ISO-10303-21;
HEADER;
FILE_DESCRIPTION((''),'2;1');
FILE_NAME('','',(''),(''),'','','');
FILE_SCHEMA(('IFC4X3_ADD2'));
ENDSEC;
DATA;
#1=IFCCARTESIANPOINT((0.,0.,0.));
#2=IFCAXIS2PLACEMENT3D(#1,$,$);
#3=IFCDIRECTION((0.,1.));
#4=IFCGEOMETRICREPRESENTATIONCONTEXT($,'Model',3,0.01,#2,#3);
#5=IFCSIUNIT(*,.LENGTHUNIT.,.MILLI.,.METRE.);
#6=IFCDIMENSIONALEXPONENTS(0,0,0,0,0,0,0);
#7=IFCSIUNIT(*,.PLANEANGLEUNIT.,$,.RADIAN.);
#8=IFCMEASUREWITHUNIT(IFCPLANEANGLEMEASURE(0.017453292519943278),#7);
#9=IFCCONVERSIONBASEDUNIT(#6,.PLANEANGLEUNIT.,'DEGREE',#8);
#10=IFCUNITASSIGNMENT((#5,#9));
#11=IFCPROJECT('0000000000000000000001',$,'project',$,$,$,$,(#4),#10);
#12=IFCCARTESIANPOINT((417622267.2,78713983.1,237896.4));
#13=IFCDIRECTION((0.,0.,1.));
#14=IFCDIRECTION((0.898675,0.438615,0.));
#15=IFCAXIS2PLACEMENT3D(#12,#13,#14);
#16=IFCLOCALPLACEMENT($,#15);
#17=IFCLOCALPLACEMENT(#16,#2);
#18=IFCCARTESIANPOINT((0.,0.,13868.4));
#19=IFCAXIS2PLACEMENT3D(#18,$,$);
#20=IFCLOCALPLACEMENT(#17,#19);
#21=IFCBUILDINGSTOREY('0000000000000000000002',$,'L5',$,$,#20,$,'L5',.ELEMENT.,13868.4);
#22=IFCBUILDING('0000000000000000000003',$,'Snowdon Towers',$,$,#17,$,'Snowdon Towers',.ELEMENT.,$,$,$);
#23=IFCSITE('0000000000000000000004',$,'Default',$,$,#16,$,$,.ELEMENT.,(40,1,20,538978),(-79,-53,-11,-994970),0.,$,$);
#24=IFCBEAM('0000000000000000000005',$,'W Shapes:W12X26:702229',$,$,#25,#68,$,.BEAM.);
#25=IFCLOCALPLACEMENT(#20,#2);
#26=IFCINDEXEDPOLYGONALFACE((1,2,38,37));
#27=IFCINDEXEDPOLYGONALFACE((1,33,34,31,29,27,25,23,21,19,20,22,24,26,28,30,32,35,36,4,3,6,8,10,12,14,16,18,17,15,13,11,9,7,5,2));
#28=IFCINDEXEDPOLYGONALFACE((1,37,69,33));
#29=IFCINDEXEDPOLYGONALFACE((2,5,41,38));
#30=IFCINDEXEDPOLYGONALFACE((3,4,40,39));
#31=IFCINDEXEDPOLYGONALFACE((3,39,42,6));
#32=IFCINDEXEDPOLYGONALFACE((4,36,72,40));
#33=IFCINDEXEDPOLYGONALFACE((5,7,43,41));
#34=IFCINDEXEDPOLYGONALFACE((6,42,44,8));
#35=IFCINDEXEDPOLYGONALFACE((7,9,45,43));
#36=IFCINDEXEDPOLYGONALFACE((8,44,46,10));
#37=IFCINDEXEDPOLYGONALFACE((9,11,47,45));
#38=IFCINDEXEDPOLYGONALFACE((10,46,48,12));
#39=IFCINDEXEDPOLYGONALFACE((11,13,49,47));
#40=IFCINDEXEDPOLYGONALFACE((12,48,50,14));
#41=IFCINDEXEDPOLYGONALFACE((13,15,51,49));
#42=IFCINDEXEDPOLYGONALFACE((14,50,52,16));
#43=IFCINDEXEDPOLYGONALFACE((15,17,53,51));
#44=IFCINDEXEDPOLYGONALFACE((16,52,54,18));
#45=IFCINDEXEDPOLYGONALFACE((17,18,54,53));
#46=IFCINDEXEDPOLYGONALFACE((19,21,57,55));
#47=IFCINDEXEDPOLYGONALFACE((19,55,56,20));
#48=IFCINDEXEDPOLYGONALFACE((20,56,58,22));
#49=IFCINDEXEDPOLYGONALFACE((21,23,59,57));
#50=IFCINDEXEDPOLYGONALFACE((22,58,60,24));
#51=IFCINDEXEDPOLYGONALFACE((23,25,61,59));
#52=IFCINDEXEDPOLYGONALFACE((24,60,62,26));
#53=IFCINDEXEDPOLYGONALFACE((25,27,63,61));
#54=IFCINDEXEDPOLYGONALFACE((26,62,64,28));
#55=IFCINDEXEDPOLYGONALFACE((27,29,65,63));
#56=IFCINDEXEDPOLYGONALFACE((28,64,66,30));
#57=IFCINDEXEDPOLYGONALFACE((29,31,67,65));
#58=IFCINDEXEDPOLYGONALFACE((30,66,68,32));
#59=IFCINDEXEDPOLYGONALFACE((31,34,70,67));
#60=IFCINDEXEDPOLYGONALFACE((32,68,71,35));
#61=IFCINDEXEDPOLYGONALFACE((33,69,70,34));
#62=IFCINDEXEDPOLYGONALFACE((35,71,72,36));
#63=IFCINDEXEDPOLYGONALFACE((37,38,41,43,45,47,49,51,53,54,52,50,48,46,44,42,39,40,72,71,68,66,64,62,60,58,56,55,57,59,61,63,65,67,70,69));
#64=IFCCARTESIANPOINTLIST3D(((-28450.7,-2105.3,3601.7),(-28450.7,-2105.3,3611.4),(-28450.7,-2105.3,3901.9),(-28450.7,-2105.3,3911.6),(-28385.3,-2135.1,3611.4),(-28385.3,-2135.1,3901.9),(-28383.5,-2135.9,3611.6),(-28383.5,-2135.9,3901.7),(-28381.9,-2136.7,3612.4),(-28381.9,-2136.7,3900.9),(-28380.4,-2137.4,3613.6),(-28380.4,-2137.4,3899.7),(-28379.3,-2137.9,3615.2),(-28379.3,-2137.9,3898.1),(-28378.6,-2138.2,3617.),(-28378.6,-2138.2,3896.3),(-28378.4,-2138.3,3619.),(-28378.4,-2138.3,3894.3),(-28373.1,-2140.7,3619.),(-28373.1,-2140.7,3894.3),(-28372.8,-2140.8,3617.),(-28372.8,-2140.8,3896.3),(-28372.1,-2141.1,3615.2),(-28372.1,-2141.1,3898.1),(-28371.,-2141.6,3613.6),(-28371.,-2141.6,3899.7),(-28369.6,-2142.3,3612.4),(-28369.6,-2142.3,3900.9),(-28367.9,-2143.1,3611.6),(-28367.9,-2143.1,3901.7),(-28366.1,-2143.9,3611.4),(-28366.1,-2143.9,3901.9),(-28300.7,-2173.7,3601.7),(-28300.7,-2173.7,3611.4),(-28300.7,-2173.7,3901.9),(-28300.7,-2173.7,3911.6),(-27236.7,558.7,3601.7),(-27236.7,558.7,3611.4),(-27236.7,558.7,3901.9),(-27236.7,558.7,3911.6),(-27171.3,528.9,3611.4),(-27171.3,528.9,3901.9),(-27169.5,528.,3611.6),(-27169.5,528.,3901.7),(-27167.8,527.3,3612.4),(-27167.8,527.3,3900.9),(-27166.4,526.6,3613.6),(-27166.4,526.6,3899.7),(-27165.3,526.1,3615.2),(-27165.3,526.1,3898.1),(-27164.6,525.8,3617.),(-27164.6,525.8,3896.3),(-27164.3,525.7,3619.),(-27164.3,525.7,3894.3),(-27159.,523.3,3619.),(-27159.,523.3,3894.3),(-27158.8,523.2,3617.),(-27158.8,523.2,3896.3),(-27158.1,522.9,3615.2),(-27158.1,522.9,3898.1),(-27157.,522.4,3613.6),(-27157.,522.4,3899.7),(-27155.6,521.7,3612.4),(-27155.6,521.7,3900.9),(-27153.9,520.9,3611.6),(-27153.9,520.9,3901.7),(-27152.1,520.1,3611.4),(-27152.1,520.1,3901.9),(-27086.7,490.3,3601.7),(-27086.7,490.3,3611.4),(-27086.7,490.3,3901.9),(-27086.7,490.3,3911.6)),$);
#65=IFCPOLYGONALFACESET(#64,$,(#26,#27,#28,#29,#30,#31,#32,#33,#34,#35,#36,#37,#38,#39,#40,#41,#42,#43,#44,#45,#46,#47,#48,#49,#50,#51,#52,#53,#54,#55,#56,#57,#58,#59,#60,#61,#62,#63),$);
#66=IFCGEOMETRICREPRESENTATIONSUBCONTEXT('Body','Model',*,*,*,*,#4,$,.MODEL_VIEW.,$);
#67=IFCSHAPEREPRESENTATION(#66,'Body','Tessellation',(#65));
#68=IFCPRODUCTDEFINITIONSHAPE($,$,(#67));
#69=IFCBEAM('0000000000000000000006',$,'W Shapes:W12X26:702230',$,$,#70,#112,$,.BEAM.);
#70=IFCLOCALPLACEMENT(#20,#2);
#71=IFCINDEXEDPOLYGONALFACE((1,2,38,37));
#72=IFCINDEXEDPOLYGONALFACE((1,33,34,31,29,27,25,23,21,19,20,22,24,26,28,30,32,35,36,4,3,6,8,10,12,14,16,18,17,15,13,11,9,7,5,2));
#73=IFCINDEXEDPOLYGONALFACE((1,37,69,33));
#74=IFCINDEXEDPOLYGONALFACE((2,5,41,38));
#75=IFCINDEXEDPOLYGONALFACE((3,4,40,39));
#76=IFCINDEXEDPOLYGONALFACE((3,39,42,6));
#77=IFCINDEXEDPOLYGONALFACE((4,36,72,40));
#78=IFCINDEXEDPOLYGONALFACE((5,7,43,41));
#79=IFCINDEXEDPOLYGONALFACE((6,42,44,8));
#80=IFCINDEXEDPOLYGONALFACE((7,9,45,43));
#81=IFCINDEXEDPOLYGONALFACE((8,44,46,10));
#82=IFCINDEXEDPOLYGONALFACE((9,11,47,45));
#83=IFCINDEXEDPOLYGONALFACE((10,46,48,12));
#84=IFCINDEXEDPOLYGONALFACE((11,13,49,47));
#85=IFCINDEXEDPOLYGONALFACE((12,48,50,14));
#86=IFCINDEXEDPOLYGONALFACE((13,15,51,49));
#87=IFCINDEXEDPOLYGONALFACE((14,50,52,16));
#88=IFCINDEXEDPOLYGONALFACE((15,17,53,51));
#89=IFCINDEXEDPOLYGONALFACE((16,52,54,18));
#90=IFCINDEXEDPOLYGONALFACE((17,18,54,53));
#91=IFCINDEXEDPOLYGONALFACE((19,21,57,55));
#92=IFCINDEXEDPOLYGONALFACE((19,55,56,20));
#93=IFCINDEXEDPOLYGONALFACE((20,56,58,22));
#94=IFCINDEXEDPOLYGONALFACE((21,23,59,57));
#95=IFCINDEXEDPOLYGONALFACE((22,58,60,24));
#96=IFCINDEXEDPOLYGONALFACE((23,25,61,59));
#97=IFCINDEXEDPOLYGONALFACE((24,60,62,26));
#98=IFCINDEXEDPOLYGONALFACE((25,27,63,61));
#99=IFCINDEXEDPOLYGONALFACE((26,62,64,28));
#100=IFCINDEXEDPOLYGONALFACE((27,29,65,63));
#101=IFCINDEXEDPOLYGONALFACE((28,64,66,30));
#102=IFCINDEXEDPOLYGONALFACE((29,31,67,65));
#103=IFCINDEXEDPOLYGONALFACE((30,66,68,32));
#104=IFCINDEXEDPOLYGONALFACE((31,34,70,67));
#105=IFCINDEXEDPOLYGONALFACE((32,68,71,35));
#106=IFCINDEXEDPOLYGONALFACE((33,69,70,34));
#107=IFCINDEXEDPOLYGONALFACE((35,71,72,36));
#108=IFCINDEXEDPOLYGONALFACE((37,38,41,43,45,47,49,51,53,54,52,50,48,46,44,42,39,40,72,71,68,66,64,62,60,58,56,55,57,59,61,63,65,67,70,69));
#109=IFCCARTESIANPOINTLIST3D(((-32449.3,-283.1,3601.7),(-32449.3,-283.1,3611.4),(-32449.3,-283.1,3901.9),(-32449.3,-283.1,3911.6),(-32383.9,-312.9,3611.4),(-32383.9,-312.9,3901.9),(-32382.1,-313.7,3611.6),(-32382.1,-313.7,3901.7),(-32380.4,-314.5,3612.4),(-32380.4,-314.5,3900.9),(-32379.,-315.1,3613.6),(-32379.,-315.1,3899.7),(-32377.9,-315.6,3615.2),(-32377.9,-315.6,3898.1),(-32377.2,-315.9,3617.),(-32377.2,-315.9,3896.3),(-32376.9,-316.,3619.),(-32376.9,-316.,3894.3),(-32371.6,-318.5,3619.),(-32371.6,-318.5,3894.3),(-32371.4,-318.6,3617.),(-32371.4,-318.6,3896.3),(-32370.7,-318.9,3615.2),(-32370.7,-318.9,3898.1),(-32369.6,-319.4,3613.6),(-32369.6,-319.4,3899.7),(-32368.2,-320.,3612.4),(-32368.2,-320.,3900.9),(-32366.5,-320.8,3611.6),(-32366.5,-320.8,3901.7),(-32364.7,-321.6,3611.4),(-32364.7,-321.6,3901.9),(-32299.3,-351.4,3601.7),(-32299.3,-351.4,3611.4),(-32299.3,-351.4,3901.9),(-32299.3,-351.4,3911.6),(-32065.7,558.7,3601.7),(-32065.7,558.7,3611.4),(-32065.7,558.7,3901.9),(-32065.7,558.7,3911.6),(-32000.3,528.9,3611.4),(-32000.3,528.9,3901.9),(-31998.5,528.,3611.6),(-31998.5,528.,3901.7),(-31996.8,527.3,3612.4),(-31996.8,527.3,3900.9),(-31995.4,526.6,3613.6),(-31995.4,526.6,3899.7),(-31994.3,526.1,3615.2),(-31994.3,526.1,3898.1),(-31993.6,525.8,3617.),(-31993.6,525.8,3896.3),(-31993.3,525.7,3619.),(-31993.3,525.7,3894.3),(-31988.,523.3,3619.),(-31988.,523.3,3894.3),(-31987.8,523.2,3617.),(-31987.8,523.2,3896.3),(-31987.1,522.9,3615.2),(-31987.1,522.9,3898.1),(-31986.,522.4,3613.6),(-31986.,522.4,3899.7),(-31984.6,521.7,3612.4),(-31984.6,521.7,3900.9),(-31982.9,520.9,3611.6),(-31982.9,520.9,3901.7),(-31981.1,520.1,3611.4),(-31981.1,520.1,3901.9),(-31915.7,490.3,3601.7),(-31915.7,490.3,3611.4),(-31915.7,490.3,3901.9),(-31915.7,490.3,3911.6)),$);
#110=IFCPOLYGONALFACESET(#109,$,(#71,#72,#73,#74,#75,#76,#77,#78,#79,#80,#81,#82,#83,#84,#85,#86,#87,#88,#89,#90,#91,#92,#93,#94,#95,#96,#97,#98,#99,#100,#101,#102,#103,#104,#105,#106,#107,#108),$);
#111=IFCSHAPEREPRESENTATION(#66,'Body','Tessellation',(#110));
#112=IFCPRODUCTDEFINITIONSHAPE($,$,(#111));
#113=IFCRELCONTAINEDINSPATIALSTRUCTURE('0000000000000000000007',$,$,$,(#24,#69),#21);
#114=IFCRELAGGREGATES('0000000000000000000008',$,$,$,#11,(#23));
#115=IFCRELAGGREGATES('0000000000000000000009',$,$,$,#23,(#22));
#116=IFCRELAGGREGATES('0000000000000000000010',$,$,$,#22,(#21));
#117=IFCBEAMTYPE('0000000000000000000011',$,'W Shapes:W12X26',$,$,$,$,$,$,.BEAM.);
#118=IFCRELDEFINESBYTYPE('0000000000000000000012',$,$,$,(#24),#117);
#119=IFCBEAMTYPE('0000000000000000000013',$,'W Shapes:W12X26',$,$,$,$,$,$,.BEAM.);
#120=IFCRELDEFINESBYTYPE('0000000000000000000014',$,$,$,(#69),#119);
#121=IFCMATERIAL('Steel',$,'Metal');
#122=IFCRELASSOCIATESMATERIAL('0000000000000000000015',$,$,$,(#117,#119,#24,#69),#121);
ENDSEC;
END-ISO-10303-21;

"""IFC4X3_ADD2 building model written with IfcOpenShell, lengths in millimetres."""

from ifc_helpers import new_model, entity, si_unit, converted_unit, direction, frame, frame_2d, origin, place, context, subcontext, project, spatial, polyline, circle_curve, parameter, trimmed, segment, composite_curve, outline, extrude, source, transform, mapped, material, material_profile, profile_set, profile_usage, type_object, type_shapes, element, save


model = new_model("IFC4X3_ADD2")

# Units and contexts
model_context = context("Model", 3, precision=0.01, world=origin(), true_north=direction((0.0, 1.0)))
body_context = subcontext(model_context, "Body", "Model", "MODEL_VIEW")
ifc_project = project(units=[si_unit("LENGTHUNIT", "METRE", prefix="MILLI"), converted_unit("PLANEANGLEUNIT", "DEGREE", entity("IfcPlaneAngleMeasure", 0.017453292519943278), si_unit("PLANEANGLEUNIT", "RADIAN"), dimensions=[0, 0, 0, 0, 0, 0, 0])], contexts=[model_context])

# Site, building, storey
site_placement = place(None, frame((417622267.2, 78713983.1, 237896.4), z_axis=(0.0, 0.0, 1.0), x_axis=(0.898675, 0.438615, 0.0)))
site = spatial("IfcSite", under=ifc_project, at=site_placement, Name="Default", CompositionType="ELEMENT", RefLatitude=(40, 1, 20, 538978), RefLongitude=(-79, -53, -11, -994970), RefElevation=0.0)
building_placement = place(site_placement, origin())
building = spatial("IfcBuilding", under=site, at=building_placement, Name="Snowdon Towers", LongName="Snowdon Towers", CompositionType="ELEMENT")
storey_placement = place(building_placement, frame((0.0, 0.0, 13868.4)))
storey = spatial("IfcBuildingStorey", under=building, at=storey_placement, Name="L5", LongName="L5", CompositionType="ELEMENT", Elevation=13868.4)

# Shared definitions
ifc_material_1 = material(Name="Steel", Category="Metal")

# Beams
ifc_material_profile_1 = material_profile(ifc_material_1, outline(composite_curve([segment(polyline([(-82.4, -145.3), (-82.4, -154.9)]), True, "CONTINUOUS"), segment(polyline([(-82.4, -154.9), (82.4, -154.9)]), True, "CONTINUOUS"), segment(polyline([(82.4, -154.9), (82.4, -145.3)]), True, "CONTINUOUS"), segment(polyline([(82.4, -145.3), (10.5, -145.3)]), True, "CONTINUOUS"), segment(trimmed(circle_curve(frame_2d((10.5, -137.7), x_axis=(1.0, 0.0)), 7.6), [parameter(180.0)], [parameter(270.0)], True, "PARAMETER"), False, "CONTINUOUS"), segment(polyline([(2.9, -137.7), (2.9, 137.7)]), True, "CONTINUOUS"), segment(trimmed(circle_curve(frame_2d((10.5, 137.7), x_axis=(1.0, 0.0)), 7.6), [parameter(90.0)], [parameter(180.0)], True, "PARAMETER"), False, "CONTINUOUS"), segment(polyline([(10.5, 145.3), (82.4, 145.3)]), True, "CONTINUOUS"), segment(polyline([(82.4, 145.3), (82.4, 154.9)]), True, "CONTINUOUS"), segment(polyline([(82.4, 154.9), (-82.4, 154.9)]), True, "CONTINUOUS"), segment(polyline([(-82.4, 154.9), (-82.4, 145.3)]), True, "CONTINUOUS"), segment(polyline([(-82.4, 145.3), (-10.5, 145.3)]), True, "CONTINUOUS"), segment(trimmed(circle_curve(frame_2d((-10.5, 137.7), x_axis=(1.0, 0.0)), 7.6), [parameter(360.0)], [parameter(90.0)], True, "PARAMETER"), False, "CONTINUOUS"), segment(polyline([(-2.9, 137.7), (-2.9, -137.7)]), True, "CONTINUOUS"), segment(trimmed(circle_curve(frame_2d((-10.5, -137.7), x_axis=(1.0, 0.0)), 7.6), [parameter(270.0)], [parameter(360.0)], True, "PARAMETER"), False, "CONTINUOUS"), segment(polyline([(-10.5, -145.3), (-82.4, -145.3)]), True, "CONTINUOUS")], self_intersect=False)), Name="W12X26")
ifc_profile_set_1 = profile_set([ifc_material_profile_1], Name="W12X26")
ifc_profile_usage_1 = profile_usage(ifc_profile_set_1, cardinal=8)
beam_type_1 = type_object("IfcBeamType", Name="W Shapes:W12X26", PredefinedType="BEAM", material=ifc_profile_set_1)
shared_shape_1 = source(origin(), body_context, "Body", "SweptSolid", [
    extrude(outline(composite_curve([segment(polyline([(-82.4, -145.3), (-82.4, -154.9)]), True, "CONTINUOUS"), segment(polyline([(-82.4, -154.9), (82.4, -154.9)]), True, "CONTINUOUS"), segment(polyline([(82.4, -154.9), (82.4, -145.3)]), True, "CONTINUOUS"), segment(polyline([(82.4, -145.3), (10.5, -145.3)]), True, "CONTINUOUS"), segment(trimmed(circle_curve(frame_2d((10.5, -137.7), x_axis=(1.0, 0.0)), 7.6), [parameter(180.0)], [parameter(270.0)], True, "PARAMETER"), False, "CONTINUOUS"), segment(polyline([(2.9, -137.7), (2.9, 137.7)]), True, "CONTINUOUS"), segment(trimmed(circle_curve(frame_2d((10.5, 137.7), x_axis=(1.0, 0.0)), 7.6), [parameter(90.0)], [parameter(180.0)], True, "PARAMETER"), False, "CONTINUOUS"), segment(polyline([(10.5, 145.3), (82.4, 145.3)]), True, "CONTINUOUS"), segment(polyline([(82.4, 145.3), (82.4, 154.9)]), True, "CONTINUOUS"), segment(polyline([(82.4, 154.9), (-82.4, 154.9)]), True, "CONTINUOUS"), segment(polyline([(-82.4, 154.9), (-82.4, 145.3)]), True, "CONTINUOUS"), segment(polyline([(-82.4, 145.3), (-10.5, 145.3)]), True, "CONTINUOUS"), segment(trimmed(circle_curve(frame_2d((-10.5, 137.7), x_axis=(1.0, 0.0)), 7.6), [parameter(360.0)], [parameter(90.0)], True, "PARAMETER"), False, "CONTINUOUS"), segment(polyline([(-2.9, 137.7), (-2.9, -137.7)]), True, "CONTINUOUS"), segment(trimmed(circle_curve(frame_2d((-10.5, -137.7), x_axis=(1.0, 0.0)), 7.6), [parameter(270.0)], [parameter(360.0)], True, "PARAMETER"), False, "CONTINUOUS"), segment(polyline([(-10.5, -145.3), (-82.4, -145.3)]), True, "CONTINUOUS")], self_intersect=False)), frame((-1546.7, 0.0, 0.0), z_axis=(-1.0, 0.0, 0.0), x_axis=(0.0, -1.0, 0.0)), (0.0, 0.0, -1.0), 2927.6),
])
type_shapes(beam_type_1, [shared_shape_1])
beam_1_placement = place(storey_placement, frame((-27734.3, -732.0, 3756.7), z_axis=(0.0, 0.0, 1.0), x_axis=(0.414693, 0.909961, 0.0)))
element("IfcBeam", 1, at=beam_1_placement, inside=storey, type_object=beam_type_1, material=ifc_profile_usage_1, Name="W Shapes:W12X26:702229", PredefinedType="BEAM", context=body_context, shape_type="MappedRepresentation", body=[
    mapped(shared_shape_1, transform((0.0, 0.0, 0.0), scale=1.0)),
])
beam_type_2 = type_object("IfcBeamType", Name="W Shapes:W12X26", PredefinedType="BEAM", material=ifc_profile_set_1)
shared_shape_2 = source(origin(), body_context, "Body", "SweptSolid", [
    extrude(outline(composite_curve([segment(polyline([(-82.4, -145.3), (-82.4, -154.9)]), True, "CONTINUOUS"), segment(polyline([(-82.4, -154.9), (82.4, -154.9)]), True, "CONTINUOUS"), segment(polyline([(82.4, -154.9), (82.4, -145.3)]), True, "CONTINUOUS"), segment(polyline([(82.4, -145.3), (10.5, -145.3)]), True, "CONTINUOUS"), segment(trimmed(circle_curve(frame_2d((10.5, -137.7), x_axis=(0.0, -1.0)), 7.6), [parameter(270.0)], [parameter(360.0)], True, "PARAMETER"), False, "CONTINUOUS"), segment(polyline([(2.9, -137.7), (2.9, 137.7)]), True, "CONTINUOUS"), segment(trimmed(circle_curve(frame_2d((10.5, 137.7), x_axis=(-1.0, 0.0)), 7.6), [parameter(270.0)], [parameter(360.0)], True, "PARAMETER"), False, "CONTINUOUS"), segment(polyline([(10.5, 145.3), (82.4, 145.3)]), True, "CONTINUOUS"), segment(polyline([(82.4, 145.3), (82.4, 154.9)]), True, "CONTINUOUS"), segment(polyline([(82.4, 154.9), (-82.4, 154.9)]), True, "CONTINUOUS"), segment(polyline([(-82.4, 154.9), (-82.4, 145.3)]), True, "CONTINUOUS"), segment(polyline([(-82.4, 145.3), (-10.5, 145.3)]), True, "CONTINUOUS"), segment(trimmed(circle_curve(frame_2d((-10.5, 137.7), x_axis=(0.0, 1.0)), 7.6), [parameter(270.0)], [parameter(0.0)], True, "PARAMETER"), False, "CONTINUOUS"), segment(polyline([(-2.9, 137.7), (-2.9, -137.7)]), True, "CONTINUOUS"), segment(trimmed(circle_curve(frame_2d((-10.5, -137.7), x_axis=(1.0, 0.0)), 7.6), [parameter(270.0)], [parameter(0.0)], True, "PARAMETER"), False, "CONTINUOUS"), segment(polyline([(-10.5, -145.3), (-82.4, -145.3)]), True, "CONTINUOUS")], self_intersect=False)), frame((-545.5, 0.0, 0.0), z_axis=(-1.0, 0.0, 0.0), x_axis=(0.0, -1.0, 0.0)), (0.0, 0.0, -1.0), 925.0),
])
type_shapes(beam_type_2, [shared_shape_2])
beam_2_placement = place(storey_placement, frame((-32148.1, 179.1, 3756.7), z_axis=(0.0, 0.0, 1.0), x_axis=(0.414693, 0.909961, 0.0)))
element("IfcBeam", 2, at=beam_2_placement, inside=storey, type_object=beam_type_2, material=ifc_profile_usage_1, Name="W Shapes:W12X26:702230", PredefinedType="BEAM", context=body_context, shape_type="MappedRepresentation", body=[
    mapped(shared_shape_2, transform((0.0, 0.0, 0.0), scale=1.0)),
])

save(model, "model.ifc")
